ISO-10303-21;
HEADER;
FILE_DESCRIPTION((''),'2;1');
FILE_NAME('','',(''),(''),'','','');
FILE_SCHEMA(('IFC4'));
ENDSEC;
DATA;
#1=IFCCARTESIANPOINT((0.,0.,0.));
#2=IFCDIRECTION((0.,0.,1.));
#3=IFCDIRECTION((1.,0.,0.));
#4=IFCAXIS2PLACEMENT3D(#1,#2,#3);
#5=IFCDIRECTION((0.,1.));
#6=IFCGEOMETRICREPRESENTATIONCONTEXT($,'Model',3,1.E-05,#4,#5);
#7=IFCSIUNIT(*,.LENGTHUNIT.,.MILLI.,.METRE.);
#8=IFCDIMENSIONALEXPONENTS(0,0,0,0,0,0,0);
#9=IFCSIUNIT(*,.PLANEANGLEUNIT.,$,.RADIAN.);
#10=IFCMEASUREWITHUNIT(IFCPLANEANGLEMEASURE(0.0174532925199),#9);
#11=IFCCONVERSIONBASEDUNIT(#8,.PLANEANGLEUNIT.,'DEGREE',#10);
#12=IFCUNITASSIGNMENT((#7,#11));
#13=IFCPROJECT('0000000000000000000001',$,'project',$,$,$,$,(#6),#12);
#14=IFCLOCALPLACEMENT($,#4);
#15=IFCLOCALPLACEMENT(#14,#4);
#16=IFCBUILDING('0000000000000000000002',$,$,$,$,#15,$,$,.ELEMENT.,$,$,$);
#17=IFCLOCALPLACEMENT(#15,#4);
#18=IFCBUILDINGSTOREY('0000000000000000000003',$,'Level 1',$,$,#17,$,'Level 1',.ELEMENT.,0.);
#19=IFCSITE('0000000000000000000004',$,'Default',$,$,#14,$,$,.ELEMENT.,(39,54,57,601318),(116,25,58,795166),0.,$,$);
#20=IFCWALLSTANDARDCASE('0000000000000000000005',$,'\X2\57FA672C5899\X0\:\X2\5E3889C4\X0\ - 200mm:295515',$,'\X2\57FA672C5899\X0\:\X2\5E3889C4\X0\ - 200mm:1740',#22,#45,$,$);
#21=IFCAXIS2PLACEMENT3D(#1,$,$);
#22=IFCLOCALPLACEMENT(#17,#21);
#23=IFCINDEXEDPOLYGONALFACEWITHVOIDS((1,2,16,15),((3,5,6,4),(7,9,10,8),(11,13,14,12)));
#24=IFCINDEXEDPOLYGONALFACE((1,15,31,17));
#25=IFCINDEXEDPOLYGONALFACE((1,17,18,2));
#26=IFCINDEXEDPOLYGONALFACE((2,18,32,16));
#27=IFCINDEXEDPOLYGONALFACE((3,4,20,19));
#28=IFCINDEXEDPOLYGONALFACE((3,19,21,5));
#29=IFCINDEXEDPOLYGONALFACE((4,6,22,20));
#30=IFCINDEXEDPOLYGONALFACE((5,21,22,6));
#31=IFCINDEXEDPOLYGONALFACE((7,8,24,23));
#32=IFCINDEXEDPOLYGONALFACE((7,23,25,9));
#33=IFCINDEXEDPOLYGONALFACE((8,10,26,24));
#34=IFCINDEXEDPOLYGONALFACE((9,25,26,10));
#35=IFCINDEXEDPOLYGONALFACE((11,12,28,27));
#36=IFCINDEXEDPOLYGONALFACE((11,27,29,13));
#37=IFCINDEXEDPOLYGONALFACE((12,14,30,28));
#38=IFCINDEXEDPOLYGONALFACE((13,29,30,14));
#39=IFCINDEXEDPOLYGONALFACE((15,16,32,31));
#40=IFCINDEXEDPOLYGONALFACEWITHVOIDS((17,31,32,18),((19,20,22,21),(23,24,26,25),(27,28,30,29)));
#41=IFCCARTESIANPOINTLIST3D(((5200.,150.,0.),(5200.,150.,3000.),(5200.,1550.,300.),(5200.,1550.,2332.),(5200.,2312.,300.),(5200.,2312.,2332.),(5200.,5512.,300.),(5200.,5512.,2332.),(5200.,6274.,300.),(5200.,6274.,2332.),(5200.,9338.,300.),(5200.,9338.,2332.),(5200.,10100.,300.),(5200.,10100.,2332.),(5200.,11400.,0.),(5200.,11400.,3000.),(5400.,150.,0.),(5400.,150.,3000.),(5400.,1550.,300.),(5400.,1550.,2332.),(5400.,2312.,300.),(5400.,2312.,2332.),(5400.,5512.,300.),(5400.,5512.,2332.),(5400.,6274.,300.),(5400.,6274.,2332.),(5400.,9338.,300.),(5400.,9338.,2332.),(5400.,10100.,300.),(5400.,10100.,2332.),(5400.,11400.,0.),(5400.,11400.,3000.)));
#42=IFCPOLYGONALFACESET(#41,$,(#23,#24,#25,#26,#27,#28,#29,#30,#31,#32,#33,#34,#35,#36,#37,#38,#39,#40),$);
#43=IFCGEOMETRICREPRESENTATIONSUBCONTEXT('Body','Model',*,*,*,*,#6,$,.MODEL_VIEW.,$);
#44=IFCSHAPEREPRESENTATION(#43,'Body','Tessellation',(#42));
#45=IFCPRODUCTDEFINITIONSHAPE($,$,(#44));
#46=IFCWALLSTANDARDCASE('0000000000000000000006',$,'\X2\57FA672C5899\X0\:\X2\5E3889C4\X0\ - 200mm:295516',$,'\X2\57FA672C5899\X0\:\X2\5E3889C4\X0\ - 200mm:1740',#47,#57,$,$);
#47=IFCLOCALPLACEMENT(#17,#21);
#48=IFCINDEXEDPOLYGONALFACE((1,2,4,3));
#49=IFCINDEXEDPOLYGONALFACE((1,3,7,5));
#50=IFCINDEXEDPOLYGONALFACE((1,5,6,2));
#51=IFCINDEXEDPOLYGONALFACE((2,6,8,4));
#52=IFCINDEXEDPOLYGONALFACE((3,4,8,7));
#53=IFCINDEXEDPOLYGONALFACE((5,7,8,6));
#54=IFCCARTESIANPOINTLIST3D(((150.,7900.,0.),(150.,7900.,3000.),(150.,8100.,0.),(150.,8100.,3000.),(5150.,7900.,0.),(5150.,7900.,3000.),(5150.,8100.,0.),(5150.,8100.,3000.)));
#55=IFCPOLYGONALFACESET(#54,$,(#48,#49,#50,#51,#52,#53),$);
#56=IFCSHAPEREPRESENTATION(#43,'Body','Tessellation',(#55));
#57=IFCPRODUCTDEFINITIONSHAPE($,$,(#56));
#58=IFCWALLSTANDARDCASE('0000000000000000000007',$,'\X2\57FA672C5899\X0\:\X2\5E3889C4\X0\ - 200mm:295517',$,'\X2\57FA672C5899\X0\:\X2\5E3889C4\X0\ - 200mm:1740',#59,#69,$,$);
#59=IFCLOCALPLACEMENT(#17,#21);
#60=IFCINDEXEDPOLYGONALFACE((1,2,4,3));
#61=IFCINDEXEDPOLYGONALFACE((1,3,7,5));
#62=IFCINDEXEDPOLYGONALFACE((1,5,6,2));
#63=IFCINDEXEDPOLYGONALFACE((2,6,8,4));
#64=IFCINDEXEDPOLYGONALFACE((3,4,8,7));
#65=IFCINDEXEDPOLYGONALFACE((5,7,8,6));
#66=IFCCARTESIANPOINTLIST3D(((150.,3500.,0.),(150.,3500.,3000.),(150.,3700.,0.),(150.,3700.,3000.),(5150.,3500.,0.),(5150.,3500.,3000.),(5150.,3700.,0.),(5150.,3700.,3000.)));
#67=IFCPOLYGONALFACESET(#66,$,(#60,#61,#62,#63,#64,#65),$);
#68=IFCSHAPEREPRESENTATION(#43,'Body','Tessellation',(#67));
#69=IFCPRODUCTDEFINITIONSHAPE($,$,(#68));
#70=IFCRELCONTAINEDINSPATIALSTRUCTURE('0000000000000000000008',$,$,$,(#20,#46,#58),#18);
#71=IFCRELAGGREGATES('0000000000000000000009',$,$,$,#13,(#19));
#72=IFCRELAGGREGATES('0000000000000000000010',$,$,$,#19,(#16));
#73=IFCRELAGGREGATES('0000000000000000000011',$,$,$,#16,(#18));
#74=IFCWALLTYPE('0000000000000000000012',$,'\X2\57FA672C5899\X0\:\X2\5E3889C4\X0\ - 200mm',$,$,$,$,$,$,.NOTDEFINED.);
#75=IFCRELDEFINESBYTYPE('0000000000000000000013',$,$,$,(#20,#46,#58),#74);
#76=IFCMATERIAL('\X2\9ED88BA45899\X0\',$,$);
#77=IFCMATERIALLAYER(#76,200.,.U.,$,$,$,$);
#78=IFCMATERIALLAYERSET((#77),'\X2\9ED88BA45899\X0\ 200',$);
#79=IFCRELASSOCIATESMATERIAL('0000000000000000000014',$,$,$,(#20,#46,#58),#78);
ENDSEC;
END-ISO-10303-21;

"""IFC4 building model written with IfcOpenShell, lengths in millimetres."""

from ifc_helpers import new_model, entity, si_unit, converted_unit, direction, frame, origin_with_axes, place, context, subcontext, project, spatial, polyline, outline, extrude, material, layer, layer_set, layer_usage, type_object, element, save


model = new_model("IFC4")

# Units and contexts
model_context = context("Model", 3, precision=1e-05, world=origin_with_axes(), true_north=direction((0.0, 1.0)))
body_context = subcontext(model_context, "Body", "Model", "MODEL_VIEW")
ifc_project = project(units=[si_unit("LENGTHUNIT", "METRE", prefix="MILLI"), converted_unit("PLANEANGLEUNIT", "DEGREE", entity("IfcPlaneAngleMeasure", 0.0174532925199), si_unit("PLANEANGLEUNIT", "RADIAN"), dimensions=[0, 0, 0, 0, 0, 0, 0])], contexts=[model_context])

# Site, building, storey
site_placement = place(None, origin_with_axes())
site = spatial("IfcSite", under=ifc_project, at=site_placement, Name="Default", CompositionType="ELEMENT", RefLatitude=(39, 54, 57, 601318), RefLongitude=(116, 25, 58, 795166), RefElevation=0.0)
building_placement = place(site_placement, origin_with_axes())
building = spatial("IfcBuilding", under=site, at=building_placement, CompositionType="ELEMENT")
storey_placement = place(building_placement, origin_with_axes())
storey = spatial("IfcBuildingStorey", under=building, at=storey_placement, Name="Level 1", LongName="Level 1", CompositionType="ELEMENT", Elevation=0.0)

# Shared definitions
ifc_material_1 = material(Name="默认墙")
ifc_layer_1 = layer(ifc_material_1, 200.0, ventilated="UNKNOWN")
ifc_layer_set_1 = layer_set([ifc_layer_1], Name="默认墙 200")
wall_type = type_object("IfcWallType", Name="基本墙:常规 - 200mm", PredefinedType="NOTDEFINED")

# Wall, openings
ifc_layer_usage_1 = layer_usage(ifc_layer_set_1, "AXIS2", "POSITIVE", -100.0)
wall_1_placement = place(storey_placement, frame((5300.0, 11500.0, 0.0), z_axis=(0.0, 0.0, 1.0), x_axis=(0.0, -1.0, 0.0)))
wall_1 = element("IfcWallStandardCase", 1, at=wall_1_placement, inside=storey, type_object=wall_type, material=ifc_layer_usage_1, Name="基本墙:常规 - 200mm:295515", ObjectType="基本墙:常规 - 200mm:1740", context=body_context, shape_type="SweptSolid", body=[
    extrude(outline(polyline([(100.0, -100.0), (11350.0, -100.0), (11350.0, 100.0), (100.0, 100.0), (100.0, -100.0)])), origin_with_axes(), (0.0, 0.0, 1.0), 3000.0),
])
opening_1_placement = place(wall_1_placement, frame((1781.0, 0.0, 300.0), z_axis=(0.0, 0.0, 1.0), x_axis=(1.0, 0.0, 0.0)))
element("IfcOpeningElement", 2, at=opening_1_placement, cuts=wall_1, context=body_context, shape_type="SweptSolid", body=[
    extrude(outline(polyline([(-381.0, -2032.0), (381.0, -2032.0), (381.0, 0.0), (-381.0, 0.0), (-381.0, -2032.0)])), frame((0.0, -100.0, 0.0), z_axis=(0.0, 1.0, 0.0), x_axis=(1.0, 0.0, 0.0)), (0.0, 0.0, 1.0), 200.0),
])
opening_2_placement = place(wall_1_placement, frame((9569.0, 0.0, 300.0), z_axis=(0.0, 0.0, 1.0), x_axis=(1.0, 0.0, 0.0)))
element("IfcOpeningElement", 3, at=opening_2_placement, cuts=wall_1, context=body_context, shape_type="SweptSolid", body=[
    extrude(outline(polyline([(-381.0, -2032.0), (381.0, -2032.0), (381.0, 0.0), (-381.0, 0.0), (-381.0, -2032.0)])), frame((0.0, -100.0, 0.0), z_axis=(0.0, 1.0, 0.0), x_axis=(1.0, 0.0, 0.0)), (0.0, 0.0, 1.0), 200.0),
])
opening_3_placement = place(wall_1_placement, frame((5607.0, 0.0, 300.0), z_axis=(0.0, 0.0, 1.0), x_axis=(1.0, 0.0, 0.0)))
element("IfcOpeningElement", 4, at=opening_3_placement, cuts=wall_1, context=body_context, shape_type="SweptSolid", body=[
    extrude(outline(polyline([(-381.0, -2032.0), (381.0, -2032.0), (381.0, 0.0), (-381.0, 0.0), (-381.0, -2032.0)])), frame((0.0, -100.0, 0.0), z_axis=(0.0, 1.0, 0.0), x_axis=(1.0, 0.0, 0.0)), (0.0, 0.0, 1.0), 200.0),
])

# Walls
ifc_layer_usage_2 = layer_usage(ifc_layer_set_1, "AXIS2", "POSITIVE", -100.0)
wall_2_placement = place(storey_placement, frame((150.0, 8000.0, 0.0), z_axis=(0.0, 0.0, 1.0), x_axis=(1.0, 0.0, 0.0)))
element("IfcWallStandardCase", 5, at=wall_2_placement, inside=storey, type_object=wall_type, material=ifc_layer_usage_2, Name="基本墙:常规 - 200mm:295516", ObjectType="基本墙:常规 - 200mm:1740", context=body_context, shape_type="SweptSolid", body=[
    extrude(outline(polyline([(0.0, -100.0), (5000.0, -100.0), (5000.0, 100.0), (0.0, 100.0), (0.0, -100.0)])), origin_with_axes(), (0.0, 0.0, 1.0), 3000.0),
])
ifc_layer_usage_3 = layer_usage(ifc_layer_set_1, "AXIS2", "POSITIVE", -100.0)
wall_3_placement = place(storey_placement, frame((150.0, 3600.0, 0.0), z_axis=(0.0, 0.0, 1.0), x_axis=(1.0, 0.0, 0.0)))
element("IfcWallStandardCase", 6, at=wall_3_placement, inside=storey, type_object=wall_type, material=ifc_layer_usage_3, Name="基本墙:常规 - 200mm:295517", ObjectType="基本墙:常规 - 200mm:1740", context=body_context, shape_type="SweptSolid", body=[
    extrude(outline(polyline([(0.0, -100.0), (5000.0, -100.0), (5000.0, 100.0), (0.0, 100.0), (0.0, -100.0)])), origin_with_axes(), (0.0, 0.0, 1.0), 3000.0),
])

save(model, "model.ifc")
